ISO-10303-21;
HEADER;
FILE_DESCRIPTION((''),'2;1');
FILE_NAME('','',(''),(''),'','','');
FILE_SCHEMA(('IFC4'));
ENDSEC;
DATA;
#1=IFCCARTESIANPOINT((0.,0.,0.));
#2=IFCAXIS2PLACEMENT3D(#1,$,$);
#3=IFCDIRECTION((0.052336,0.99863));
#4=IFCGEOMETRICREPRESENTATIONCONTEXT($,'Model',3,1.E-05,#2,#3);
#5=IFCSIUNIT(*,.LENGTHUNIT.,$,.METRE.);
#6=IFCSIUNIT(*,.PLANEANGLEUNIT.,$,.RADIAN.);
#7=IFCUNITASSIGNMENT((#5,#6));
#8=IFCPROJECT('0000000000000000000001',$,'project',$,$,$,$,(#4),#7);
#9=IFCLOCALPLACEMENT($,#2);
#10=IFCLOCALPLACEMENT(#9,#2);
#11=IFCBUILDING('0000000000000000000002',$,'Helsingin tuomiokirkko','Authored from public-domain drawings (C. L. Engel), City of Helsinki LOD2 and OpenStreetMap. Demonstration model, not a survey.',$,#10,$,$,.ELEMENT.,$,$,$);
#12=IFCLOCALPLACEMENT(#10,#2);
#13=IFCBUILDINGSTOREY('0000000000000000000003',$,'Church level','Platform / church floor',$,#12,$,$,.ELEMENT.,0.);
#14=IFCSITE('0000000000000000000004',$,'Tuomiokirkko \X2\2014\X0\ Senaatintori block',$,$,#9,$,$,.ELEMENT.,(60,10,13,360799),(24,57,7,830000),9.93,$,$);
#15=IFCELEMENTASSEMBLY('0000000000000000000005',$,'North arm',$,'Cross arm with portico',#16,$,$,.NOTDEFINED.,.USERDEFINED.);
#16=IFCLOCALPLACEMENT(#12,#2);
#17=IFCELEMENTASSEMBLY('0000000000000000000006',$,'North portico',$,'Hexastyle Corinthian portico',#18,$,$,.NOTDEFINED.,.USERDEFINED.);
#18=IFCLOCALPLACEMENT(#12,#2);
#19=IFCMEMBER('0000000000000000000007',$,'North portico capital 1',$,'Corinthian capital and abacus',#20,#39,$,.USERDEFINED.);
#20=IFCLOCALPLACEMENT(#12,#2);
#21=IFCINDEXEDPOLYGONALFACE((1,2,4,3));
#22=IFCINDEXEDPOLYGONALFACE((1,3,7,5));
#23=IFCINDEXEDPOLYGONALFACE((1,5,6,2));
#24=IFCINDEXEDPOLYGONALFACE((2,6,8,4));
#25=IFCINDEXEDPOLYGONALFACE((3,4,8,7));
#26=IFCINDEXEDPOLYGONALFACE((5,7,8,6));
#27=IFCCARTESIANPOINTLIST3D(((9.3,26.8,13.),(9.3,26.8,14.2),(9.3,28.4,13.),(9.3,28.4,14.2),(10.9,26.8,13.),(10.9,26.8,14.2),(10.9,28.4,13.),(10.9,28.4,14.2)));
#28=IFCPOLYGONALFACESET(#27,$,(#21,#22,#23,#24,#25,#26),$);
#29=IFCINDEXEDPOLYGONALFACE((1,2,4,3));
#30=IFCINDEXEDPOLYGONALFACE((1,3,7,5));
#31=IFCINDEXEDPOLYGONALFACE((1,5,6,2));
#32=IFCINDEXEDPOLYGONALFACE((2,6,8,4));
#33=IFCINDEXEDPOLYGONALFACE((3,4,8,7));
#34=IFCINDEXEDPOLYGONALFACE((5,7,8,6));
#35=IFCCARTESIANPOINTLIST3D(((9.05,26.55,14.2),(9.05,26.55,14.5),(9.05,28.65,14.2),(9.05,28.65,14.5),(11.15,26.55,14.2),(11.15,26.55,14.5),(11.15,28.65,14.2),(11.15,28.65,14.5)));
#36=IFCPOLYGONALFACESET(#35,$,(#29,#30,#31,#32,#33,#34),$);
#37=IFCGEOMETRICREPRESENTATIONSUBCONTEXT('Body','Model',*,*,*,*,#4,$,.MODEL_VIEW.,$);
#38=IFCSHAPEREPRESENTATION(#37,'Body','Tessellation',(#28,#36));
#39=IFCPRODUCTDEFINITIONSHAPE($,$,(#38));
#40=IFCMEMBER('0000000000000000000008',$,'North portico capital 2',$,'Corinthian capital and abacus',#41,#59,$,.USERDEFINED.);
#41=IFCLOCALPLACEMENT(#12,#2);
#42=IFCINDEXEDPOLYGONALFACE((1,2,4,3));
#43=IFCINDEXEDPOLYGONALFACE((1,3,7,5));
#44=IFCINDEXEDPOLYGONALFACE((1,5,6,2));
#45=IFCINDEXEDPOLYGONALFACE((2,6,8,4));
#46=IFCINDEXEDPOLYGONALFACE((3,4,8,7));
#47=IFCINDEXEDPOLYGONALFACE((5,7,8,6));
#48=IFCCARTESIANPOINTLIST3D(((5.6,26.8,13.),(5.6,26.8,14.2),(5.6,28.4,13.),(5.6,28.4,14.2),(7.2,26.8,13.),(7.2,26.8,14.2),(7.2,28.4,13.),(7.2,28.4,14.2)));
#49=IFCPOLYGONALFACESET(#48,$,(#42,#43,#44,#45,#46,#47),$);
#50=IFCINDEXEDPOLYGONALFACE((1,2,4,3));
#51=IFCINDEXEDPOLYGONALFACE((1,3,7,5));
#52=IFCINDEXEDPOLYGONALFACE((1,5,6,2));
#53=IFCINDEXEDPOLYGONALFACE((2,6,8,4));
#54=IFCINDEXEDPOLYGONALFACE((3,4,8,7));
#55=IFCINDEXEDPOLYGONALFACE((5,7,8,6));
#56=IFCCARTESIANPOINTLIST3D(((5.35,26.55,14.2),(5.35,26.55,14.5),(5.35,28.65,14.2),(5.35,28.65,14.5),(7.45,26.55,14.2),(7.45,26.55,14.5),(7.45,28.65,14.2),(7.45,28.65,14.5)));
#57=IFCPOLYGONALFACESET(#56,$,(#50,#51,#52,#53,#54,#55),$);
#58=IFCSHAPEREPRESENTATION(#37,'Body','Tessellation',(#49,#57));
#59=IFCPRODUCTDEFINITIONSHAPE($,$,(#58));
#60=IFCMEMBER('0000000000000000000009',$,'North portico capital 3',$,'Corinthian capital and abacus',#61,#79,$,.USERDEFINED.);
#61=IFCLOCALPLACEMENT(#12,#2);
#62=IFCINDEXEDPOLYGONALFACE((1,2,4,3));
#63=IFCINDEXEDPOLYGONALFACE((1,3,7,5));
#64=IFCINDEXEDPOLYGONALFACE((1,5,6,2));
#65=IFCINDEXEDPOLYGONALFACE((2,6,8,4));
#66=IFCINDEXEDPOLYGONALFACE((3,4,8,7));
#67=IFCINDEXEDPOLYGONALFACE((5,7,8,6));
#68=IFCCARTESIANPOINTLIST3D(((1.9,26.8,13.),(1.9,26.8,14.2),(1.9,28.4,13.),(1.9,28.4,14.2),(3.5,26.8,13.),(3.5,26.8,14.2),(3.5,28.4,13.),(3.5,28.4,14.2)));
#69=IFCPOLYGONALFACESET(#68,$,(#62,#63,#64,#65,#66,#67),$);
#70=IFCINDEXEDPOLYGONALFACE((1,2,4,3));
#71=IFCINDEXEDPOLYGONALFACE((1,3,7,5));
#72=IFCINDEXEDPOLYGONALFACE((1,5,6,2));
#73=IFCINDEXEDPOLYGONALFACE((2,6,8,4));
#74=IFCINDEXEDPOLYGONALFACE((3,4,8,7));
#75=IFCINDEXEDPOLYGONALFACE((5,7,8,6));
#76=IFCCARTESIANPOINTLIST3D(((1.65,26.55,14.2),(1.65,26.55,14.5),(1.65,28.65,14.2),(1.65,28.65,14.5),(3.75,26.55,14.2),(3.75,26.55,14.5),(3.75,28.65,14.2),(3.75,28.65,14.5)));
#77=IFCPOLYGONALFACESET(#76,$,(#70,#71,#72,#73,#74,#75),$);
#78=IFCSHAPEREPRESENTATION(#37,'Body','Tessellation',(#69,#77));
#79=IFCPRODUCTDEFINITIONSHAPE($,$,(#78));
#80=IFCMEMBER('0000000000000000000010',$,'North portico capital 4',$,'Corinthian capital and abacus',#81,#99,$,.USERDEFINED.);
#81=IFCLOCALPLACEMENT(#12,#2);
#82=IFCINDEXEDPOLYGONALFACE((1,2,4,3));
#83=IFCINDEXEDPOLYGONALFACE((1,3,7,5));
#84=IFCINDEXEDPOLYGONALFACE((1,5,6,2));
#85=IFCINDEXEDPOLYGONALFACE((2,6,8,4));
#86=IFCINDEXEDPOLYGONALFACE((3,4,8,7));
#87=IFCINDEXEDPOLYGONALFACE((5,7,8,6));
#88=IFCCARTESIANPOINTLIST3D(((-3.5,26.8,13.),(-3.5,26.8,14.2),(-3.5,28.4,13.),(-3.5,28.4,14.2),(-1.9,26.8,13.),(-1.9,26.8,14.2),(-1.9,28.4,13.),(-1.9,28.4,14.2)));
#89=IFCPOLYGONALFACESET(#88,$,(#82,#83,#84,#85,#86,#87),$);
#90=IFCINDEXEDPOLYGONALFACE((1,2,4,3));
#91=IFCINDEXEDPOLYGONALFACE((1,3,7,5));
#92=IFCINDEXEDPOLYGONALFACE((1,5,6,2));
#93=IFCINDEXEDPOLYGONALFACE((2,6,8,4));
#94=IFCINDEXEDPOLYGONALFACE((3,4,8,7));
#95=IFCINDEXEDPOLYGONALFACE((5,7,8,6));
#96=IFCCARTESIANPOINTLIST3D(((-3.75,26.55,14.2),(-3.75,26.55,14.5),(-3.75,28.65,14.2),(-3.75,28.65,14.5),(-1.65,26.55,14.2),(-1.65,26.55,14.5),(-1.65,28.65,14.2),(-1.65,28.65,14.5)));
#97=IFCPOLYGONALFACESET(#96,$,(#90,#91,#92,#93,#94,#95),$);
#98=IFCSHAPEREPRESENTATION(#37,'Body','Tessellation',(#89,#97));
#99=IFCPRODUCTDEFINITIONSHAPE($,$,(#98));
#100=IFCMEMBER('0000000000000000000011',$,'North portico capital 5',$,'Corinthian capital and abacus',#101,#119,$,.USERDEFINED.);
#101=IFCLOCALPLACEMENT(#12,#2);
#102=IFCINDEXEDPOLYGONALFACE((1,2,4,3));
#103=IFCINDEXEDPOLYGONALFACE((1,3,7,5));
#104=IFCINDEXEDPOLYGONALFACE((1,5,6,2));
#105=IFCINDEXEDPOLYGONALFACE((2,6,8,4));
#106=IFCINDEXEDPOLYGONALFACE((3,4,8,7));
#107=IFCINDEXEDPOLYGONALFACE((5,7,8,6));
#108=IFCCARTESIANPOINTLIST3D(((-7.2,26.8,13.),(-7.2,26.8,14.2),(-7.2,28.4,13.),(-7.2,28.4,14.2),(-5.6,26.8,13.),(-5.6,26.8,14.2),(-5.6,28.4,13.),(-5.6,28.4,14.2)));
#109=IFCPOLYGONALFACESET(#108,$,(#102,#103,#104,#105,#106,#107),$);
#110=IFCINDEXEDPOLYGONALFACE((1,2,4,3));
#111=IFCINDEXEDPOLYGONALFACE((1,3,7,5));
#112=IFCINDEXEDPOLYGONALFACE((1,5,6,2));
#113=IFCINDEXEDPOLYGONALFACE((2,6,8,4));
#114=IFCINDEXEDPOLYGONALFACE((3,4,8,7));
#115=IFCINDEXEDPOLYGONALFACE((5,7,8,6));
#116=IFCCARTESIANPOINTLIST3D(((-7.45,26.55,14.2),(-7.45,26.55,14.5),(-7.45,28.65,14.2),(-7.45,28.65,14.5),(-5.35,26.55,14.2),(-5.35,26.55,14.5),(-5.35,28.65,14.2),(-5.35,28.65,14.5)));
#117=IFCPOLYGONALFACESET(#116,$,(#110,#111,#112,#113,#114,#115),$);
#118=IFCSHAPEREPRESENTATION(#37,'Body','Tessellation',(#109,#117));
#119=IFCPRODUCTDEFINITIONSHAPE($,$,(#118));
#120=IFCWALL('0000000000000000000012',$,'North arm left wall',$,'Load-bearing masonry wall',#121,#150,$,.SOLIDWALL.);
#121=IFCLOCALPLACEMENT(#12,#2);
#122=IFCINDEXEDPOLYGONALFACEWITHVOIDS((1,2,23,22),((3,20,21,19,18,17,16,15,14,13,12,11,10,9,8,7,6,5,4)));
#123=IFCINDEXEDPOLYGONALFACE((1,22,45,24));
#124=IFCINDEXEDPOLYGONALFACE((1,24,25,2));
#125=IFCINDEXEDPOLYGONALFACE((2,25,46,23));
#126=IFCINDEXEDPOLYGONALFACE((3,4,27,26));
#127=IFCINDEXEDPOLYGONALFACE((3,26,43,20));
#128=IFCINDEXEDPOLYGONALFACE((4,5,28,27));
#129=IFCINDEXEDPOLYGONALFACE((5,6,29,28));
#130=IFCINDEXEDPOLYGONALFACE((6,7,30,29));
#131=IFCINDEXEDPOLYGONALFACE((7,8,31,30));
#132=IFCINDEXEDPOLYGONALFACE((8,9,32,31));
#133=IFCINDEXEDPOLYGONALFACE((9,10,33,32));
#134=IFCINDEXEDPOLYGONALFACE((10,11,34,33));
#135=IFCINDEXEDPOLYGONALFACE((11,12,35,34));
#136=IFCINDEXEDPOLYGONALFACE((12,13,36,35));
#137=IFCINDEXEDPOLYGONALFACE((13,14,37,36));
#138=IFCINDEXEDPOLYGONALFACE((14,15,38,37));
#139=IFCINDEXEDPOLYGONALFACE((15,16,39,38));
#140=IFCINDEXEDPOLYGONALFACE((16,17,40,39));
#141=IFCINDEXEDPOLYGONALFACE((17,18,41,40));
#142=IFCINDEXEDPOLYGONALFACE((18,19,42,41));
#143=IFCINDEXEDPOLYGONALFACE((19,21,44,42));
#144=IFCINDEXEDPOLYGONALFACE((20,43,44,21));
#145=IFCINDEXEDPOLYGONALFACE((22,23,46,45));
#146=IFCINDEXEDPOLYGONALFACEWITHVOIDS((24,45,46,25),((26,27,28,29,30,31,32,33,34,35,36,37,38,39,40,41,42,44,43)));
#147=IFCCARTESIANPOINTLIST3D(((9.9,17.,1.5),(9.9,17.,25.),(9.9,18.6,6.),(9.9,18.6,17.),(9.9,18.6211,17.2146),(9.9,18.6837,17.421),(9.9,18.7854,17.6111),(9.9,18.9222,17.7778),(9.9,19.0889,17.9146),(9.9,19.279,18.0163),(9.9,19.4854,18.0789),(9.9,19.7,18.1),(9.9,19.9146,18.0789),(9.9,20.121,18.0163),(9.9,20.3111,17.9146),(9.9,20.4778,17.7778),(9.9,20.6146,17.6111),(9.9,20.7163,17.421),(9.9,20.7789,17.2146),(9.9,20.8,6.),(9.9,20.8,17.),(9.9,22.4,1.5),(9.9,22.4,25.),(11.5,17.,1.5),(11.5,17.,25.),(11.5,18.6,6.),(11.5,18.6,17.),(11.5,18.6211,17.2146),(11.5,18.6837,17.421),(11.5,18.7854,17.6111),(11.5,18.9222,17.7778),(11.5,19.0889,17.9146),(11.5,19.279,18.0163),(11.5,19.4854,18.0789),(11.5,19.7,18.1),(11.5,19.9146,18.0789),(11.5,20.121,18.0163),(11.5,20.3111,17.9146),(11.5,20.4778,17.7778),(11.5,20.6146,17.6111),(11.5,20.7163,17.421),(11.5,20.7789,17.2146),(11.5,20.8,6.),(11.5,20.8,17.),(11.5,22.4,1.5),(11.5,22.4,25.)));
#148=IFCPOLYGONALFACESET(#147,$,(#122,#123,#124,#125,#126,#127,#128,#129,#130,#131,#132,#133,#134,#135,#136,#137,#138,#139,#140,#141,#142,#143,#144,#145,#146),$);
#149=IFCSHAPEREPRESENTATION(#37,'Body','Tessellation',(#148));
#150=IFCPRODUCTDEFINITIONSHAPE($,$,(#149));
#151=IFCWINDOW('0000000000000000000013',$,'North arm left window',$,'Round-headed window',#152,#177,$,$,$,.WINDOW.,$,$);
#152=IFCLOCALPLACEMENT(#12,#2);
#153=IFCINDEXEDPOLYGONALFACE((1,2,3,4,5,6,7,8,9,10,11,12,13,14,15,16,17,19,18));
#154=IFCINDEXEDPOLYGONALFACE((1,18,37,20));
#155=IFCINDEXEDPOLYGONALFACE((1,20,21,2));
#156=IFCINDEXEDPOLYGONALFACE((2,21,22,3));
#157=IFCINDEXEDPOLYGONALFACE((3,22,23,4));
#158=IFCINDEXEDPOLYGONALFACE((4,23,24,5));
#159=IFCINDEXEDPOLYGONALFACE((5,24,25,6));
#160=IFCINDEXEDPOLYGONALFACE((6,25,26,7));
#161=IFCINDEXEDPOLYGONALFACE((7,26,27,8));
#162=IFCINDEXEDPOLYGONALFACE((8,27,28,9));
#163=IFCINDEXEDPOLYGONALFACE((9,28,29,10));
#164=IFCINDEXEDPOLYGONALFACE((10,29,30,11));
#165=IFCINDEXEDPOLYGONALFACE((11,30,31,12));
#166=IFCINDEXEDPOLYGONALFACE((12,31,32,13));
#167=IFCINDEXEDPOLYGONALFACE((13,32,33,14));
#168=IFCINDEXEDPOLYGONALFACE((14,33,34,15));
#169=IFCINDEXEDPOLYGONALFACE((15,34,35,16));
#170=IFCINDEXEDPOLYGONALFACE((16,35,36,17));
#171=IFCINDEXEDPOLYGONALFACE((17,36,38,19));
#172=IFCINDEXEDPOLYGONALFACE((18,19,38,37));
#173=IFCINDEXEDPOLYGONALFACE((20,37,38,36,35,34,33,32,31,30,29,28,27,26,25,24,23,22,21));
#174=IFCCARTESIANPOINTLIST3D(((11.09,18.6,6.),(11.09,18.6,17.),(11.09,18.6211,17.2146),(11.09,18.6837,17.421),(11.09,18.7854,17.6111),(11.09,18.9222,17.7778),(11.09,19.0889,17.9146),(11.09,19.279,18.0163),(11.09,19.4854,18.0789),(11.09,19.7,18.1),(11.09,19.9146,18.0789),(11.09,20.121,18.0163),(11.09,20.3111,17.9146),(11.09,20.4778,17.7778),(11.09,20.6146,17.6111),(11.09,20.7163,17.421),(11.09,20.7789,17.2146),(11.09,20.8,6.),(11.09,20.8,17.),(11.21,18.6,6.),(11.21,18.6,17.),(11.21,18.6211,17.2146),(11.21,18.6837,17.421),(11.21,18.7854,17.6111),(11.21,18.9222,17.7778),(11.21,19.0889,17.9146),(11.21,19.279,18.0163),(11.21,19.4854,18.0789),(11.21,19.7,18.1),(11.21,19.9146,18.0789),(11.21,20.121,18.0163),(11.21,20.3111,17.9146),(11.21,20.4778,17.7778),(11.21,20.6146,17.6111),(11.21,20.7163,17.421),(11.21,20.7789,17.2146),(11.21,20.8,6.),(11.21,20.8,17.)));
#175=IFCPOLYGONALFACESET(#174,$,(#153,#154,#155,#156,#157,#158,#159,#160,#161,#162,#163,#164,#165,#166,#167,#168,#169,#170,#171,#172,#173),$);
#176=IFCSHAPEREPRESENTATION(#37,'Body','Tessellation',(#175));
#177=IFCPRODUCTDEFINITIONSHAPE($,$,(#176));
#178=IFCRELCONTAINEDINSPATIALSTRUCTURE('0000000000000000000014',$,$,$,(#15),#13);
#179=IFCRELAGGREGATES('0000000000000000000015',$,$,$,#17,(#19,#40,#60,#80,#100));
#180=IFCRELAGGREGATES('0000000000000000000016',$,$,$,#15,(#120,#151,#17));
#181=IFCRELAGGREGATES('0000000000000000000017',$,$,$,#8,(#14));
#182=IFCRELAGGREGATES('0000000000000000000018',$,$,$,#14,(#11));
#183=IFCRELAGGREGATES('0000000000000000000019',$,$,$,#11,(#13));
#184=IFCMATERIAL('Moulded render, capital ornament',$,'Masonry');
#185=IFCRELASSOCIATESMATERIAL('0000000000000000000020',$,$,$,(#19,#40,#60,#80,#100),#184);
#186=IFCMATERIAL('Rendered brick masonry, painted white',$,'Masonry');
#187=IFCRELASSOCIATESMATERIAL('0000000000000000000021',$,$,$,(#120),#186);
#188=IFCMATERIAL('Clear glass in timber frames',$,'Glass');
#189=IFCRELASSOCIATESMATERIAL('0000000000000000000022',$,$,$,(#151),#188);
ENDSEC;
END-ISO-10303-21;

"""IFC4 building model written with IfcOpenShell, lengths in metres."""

from ifc_helpers import new_model, si_unit, direction, frame, frame_2d, origin, origin_2d_with_axis, place, context, subcontext, project, spatial, polyline, rectangle, outline, extrude, material, element, fill, aggregate, save


model = new_model("IFC4")

# Units and contexts
model_context = context("Model", 3, precision=1e-05, world=origin(), true_north=direction((0.052336, 0.99863)))
body_context = subcontext(model_context, "Body", "Model", "MODEL_VIEW")
ifc_project = project(units=[si_unit("LENGTHUNIT", "METRE"), si_unit("PLANEANGLEUNIT", "RADIAN")], contexts=[model_context])

# Site, building, storey
site_placement = place(None, origin())
site = spatial("IfcSite", under=ifc_project, at=site_placement, Name="Tuomiokirkko — Senaatintori block", CompositionType="ELEMENT", RefLatitude=(60, 10, 13, 360799), RefLongitude=(24, 57, 7, 830000), RefElevation=9.93)
building_placement = place(site_placement, origin())
building = spatial("IfcBuilding", under=site, at=building_placement, Name="Helsingin tuomiokirkko", Description="Authored from public-domain drawings (C. L. Engel), City of Helsinki LOD2 and OpenStreetMap. Demonstration model, not a survey.", CompositionType="ELEMENT")
storey_placement = place(building_placement, origin())
storey = spatial("IfcBuildingStorey", under=building, at=storey_placement, Name="Church level", Description="Platform / church floor", CompositionType="ELEMENT", Elevation=0.0)

# Element assemblies
assembly_1_placement = place(building_placement, origin())
assembly_1 = element("IfcElementAssembly", 1, at=assembly_1_placement, inside=storey, Name="North arm", ObjectType="Cross arm with portico", AssemblyPlace="NOTDEFINED", PredefinedType="USERDEFINED")
ifc_material_1 = material(Name="Rendered brick masonry, painted white", Category="Masonry")
assembly_2_placement = place(building_placement, origin())
assembly_2 = element("IfcElementAssembly", 2, at=assembly_2_placement, Name="North portico", ObjectType="Hexastyle Corinthian portico", AssemblyPlace="NOTDEFINED", PredefinedType="USERDEFINED")

# Shared definitions
ifc_material_2 = material(Name="Moulded render, capital ornament", Category="Masonry")

# Members
member_1_placement = place(building_placement, origin())
member_1 = element("IfcMember", 3, at=member_1_placement, material=ifc_material_2, Name="North portico capital 1", ObjectType="Corinthian capital and abacus", PredefinedType="USERDEFINED", context=body_context, shape_type="SweptSolid", body=[
    extrude(rectangle(XDim=1.6, YDim=1.6, at=origin_2d_with_axis()), frame((10.1, 27.6, 13.0)), (0.0, 0.0, 1.0), 1.2),
    extrude(rectangle(XDim=2.1, YDim=2.1, at=origin_2d_with_axis()), frame((10.1, 27.6, 14.2)), (0.0, 0.0, 1.0), 0.3),
])
member_2_placement = place(building_placement, origin())
member_2 = element("IfcMember", 4, at=member_2_placement, material=ifc_material_2, Name="North portico capital 2", ObjectType="Corinthian capital and abacus", PredefinedType="USERDEFINED", context=body_context, shape_type="SweptSolid", body=[
    extrude(rectangle(XDim=1.6, YDim=1.6, at=origin_2d_with_axis()), frame((6.4, 27.6, 13.0)), (0.0, 0.0, 1.0), 1.2),
    extrude(rectangle(XDim=2.1, YDim=2.1, at=origin_2d_with_axis()), frame((6.4, 27.6, 14.2)), (0.0, 0.0, 1.0), 0.3),
])
member_3_placement = place(building_placement, origin())
member_3 = element("IfcMember", 5, at=member_3_placement, material=ifc_material_2, Name="North portico capital 3", ObjectType="Corinthian capital and abacus", PredefinedType="USERDEFINED", context=body_context, shape_type="SweptSolid", body=[
    extrude(rectangle(XDim=1.6, YDim=1.6, at=origin_2d_with_axis()), frame((2.7, 27.6, 13.0)), (0.0, 0.0, 1.0), 1.2),
    extrude(rectangle(XDim=2.1, YDim=2.1, at=origin_2d_with_axis()), frame((2.7, 27.6, 14.2)), (0.0, 0.0, 1.0), 0.3),
])
member_4_placement = place(building_placement, origin())
member_4 = element("IfcMember", 6, at=member_4_placement, material=ifc_material_2, Name="North portico capital 4", ObjectType="Corinthian capital and abacus", PredefinedType="USERDEFINED", context=body_context, shape_type="SweptSolid", body=[
    extrude(rectangle(XDim=1.6, YDim=1.6, at=origin_2d_with_axis()), frame((-2.7, 27.6, 13.0)), (0.0, 0.0, 1.0), 1.2),
    extrude(rectangle(XDim=2.1, YDim=2.1, at=origin_2d_with_axis()), frame((-2.7, 27.6, 14.2)), (0.0, 0.0, 1.0), 0.3),
])
member_5_placement = place(building_placement, origin())
member_5 = element("IfcMember", 7, at=member_5_placement, material=ifc_material_2, Name="North portico capital 5", ObjectType="Corinthian capital and abacus", PredefinedType="USERDEFINED", context=body_context, shape_type="SweptSolid", body=[
    extrude(rectangle(XDim=1.6, YDim=1.6, at=origin_2d_with_axis()), frame((-6.4, 27.6, 13.0)), (0.0, 0.0, 1.0), 1.2),
    extrude(rectangle(XDim=2.1, YDim=2.1, at=origin_2d_with_axis()), frame((-6.4, 27.6, 14.2)), (0.0, 0.0, 1.0), 0.3),
])
aggregate(assembly_2, [member_1, member_2, member_3, member_4, member_5])

# Shared definitions
ifc_material_3 = material(Name="Clear glass in timber frames", Category="Glass")

# Wall, opening, window
wall_1_placement = place(building_placement, origin())
wall_1 = element("IfcWall", 8, at=wall_1_placement, material=ifc_material_1, Name="North arm left wall", ObjectType="Load-bearing masonry wall", PredefinedType="SOLIDWALL", context=body_context, shape_type="SweptSolid", body=[
    extrude(rectangle(XDim=5.4, YDim=1.6, at=frame_2d((0.0, 0.0), x_axis=(0.0, 1.0))), frame((10.7, 19.7, 1.5)), (0.0, 0.0, 1.0), 23.5),
])
opening_1_placement = place(building_placement, origin())
opening_1 = element("IfcOpeningElement", 9, at=opening_1_placement, cuts=wall_1, PredefinedType="OPENING", context=body_context, shape_type="SweptSolid", body=[
    extrude(outline(polyline([(-1.1, 0.0), (1.1, 0.0), (1.1, 11.0), (1.0789, 11.2146), (1.0163, 11.421), (0.9146, 11.6111), (0.7778, 11.7778), (0.6111, 11.9146), (0.421, 12.0163), (0.2146, 12.0789), (0.0, 12.1), (-0.2146, 12.0789), (-0.421, 12.0163), (-0.6111, 11.9146), (-0.7778, 11.7778), (-0.9146, 11.6111), (-1.0163, 11.421), (-1.0789, 11.2146), (-1.1, 11.0), (-1.1, 0.0)])), frame((9.7, 19.7, 6.0), z_axis=(1.0, 0.0, 0.0), x_axis=(0.0, 1.0, 0.0)), (0.0, 0.0, 1.0), 2.0),
])
window_1_placement = place(building_placement, origin())
window_1 = element("IfcWindow", 10, at=window_1_placement, material=ifc_material_3, Name="North arm left window", ObjectType="Round-headed window", PredefinedType="WINDOW", context=body_context, shape_type="SweptSolid", body=[
    extrude(outline(polyline([(-1.1, 0.0), (1.1, 0.0), (1.1, 11.0), (1.0789, 11.2146), (1.0163, 11.421), (0.9146, 11.6111), (0.7778, 11.7778), (0.6111, 11.9146), (0.421, 12.0163), (0.2146, 12.0789), (0.0, 12.1), (-0.2146, 12.0789), (-0.421, 12.0163), (-0.6111, 11.9146), (-0.7778, 11.7778), (-0.9146, 11.6111), (-1.0163, 11.421), (-1.0789, 11.2146), (-1.1, 11.0), (-1.1, 0.0)])), frame((11.09, 19.7, 6.0), z_axis=(1.0, 0.0, 0.0), x_axis=(0.0, 1.0, 0.0)), (0.0, 0.0, 1.0), 0.12),
])
fill(opening_1, window_1)

aggregate(assembly_1, [wall_1, window_1, assembly_2])

save(model, "model.ifc")
